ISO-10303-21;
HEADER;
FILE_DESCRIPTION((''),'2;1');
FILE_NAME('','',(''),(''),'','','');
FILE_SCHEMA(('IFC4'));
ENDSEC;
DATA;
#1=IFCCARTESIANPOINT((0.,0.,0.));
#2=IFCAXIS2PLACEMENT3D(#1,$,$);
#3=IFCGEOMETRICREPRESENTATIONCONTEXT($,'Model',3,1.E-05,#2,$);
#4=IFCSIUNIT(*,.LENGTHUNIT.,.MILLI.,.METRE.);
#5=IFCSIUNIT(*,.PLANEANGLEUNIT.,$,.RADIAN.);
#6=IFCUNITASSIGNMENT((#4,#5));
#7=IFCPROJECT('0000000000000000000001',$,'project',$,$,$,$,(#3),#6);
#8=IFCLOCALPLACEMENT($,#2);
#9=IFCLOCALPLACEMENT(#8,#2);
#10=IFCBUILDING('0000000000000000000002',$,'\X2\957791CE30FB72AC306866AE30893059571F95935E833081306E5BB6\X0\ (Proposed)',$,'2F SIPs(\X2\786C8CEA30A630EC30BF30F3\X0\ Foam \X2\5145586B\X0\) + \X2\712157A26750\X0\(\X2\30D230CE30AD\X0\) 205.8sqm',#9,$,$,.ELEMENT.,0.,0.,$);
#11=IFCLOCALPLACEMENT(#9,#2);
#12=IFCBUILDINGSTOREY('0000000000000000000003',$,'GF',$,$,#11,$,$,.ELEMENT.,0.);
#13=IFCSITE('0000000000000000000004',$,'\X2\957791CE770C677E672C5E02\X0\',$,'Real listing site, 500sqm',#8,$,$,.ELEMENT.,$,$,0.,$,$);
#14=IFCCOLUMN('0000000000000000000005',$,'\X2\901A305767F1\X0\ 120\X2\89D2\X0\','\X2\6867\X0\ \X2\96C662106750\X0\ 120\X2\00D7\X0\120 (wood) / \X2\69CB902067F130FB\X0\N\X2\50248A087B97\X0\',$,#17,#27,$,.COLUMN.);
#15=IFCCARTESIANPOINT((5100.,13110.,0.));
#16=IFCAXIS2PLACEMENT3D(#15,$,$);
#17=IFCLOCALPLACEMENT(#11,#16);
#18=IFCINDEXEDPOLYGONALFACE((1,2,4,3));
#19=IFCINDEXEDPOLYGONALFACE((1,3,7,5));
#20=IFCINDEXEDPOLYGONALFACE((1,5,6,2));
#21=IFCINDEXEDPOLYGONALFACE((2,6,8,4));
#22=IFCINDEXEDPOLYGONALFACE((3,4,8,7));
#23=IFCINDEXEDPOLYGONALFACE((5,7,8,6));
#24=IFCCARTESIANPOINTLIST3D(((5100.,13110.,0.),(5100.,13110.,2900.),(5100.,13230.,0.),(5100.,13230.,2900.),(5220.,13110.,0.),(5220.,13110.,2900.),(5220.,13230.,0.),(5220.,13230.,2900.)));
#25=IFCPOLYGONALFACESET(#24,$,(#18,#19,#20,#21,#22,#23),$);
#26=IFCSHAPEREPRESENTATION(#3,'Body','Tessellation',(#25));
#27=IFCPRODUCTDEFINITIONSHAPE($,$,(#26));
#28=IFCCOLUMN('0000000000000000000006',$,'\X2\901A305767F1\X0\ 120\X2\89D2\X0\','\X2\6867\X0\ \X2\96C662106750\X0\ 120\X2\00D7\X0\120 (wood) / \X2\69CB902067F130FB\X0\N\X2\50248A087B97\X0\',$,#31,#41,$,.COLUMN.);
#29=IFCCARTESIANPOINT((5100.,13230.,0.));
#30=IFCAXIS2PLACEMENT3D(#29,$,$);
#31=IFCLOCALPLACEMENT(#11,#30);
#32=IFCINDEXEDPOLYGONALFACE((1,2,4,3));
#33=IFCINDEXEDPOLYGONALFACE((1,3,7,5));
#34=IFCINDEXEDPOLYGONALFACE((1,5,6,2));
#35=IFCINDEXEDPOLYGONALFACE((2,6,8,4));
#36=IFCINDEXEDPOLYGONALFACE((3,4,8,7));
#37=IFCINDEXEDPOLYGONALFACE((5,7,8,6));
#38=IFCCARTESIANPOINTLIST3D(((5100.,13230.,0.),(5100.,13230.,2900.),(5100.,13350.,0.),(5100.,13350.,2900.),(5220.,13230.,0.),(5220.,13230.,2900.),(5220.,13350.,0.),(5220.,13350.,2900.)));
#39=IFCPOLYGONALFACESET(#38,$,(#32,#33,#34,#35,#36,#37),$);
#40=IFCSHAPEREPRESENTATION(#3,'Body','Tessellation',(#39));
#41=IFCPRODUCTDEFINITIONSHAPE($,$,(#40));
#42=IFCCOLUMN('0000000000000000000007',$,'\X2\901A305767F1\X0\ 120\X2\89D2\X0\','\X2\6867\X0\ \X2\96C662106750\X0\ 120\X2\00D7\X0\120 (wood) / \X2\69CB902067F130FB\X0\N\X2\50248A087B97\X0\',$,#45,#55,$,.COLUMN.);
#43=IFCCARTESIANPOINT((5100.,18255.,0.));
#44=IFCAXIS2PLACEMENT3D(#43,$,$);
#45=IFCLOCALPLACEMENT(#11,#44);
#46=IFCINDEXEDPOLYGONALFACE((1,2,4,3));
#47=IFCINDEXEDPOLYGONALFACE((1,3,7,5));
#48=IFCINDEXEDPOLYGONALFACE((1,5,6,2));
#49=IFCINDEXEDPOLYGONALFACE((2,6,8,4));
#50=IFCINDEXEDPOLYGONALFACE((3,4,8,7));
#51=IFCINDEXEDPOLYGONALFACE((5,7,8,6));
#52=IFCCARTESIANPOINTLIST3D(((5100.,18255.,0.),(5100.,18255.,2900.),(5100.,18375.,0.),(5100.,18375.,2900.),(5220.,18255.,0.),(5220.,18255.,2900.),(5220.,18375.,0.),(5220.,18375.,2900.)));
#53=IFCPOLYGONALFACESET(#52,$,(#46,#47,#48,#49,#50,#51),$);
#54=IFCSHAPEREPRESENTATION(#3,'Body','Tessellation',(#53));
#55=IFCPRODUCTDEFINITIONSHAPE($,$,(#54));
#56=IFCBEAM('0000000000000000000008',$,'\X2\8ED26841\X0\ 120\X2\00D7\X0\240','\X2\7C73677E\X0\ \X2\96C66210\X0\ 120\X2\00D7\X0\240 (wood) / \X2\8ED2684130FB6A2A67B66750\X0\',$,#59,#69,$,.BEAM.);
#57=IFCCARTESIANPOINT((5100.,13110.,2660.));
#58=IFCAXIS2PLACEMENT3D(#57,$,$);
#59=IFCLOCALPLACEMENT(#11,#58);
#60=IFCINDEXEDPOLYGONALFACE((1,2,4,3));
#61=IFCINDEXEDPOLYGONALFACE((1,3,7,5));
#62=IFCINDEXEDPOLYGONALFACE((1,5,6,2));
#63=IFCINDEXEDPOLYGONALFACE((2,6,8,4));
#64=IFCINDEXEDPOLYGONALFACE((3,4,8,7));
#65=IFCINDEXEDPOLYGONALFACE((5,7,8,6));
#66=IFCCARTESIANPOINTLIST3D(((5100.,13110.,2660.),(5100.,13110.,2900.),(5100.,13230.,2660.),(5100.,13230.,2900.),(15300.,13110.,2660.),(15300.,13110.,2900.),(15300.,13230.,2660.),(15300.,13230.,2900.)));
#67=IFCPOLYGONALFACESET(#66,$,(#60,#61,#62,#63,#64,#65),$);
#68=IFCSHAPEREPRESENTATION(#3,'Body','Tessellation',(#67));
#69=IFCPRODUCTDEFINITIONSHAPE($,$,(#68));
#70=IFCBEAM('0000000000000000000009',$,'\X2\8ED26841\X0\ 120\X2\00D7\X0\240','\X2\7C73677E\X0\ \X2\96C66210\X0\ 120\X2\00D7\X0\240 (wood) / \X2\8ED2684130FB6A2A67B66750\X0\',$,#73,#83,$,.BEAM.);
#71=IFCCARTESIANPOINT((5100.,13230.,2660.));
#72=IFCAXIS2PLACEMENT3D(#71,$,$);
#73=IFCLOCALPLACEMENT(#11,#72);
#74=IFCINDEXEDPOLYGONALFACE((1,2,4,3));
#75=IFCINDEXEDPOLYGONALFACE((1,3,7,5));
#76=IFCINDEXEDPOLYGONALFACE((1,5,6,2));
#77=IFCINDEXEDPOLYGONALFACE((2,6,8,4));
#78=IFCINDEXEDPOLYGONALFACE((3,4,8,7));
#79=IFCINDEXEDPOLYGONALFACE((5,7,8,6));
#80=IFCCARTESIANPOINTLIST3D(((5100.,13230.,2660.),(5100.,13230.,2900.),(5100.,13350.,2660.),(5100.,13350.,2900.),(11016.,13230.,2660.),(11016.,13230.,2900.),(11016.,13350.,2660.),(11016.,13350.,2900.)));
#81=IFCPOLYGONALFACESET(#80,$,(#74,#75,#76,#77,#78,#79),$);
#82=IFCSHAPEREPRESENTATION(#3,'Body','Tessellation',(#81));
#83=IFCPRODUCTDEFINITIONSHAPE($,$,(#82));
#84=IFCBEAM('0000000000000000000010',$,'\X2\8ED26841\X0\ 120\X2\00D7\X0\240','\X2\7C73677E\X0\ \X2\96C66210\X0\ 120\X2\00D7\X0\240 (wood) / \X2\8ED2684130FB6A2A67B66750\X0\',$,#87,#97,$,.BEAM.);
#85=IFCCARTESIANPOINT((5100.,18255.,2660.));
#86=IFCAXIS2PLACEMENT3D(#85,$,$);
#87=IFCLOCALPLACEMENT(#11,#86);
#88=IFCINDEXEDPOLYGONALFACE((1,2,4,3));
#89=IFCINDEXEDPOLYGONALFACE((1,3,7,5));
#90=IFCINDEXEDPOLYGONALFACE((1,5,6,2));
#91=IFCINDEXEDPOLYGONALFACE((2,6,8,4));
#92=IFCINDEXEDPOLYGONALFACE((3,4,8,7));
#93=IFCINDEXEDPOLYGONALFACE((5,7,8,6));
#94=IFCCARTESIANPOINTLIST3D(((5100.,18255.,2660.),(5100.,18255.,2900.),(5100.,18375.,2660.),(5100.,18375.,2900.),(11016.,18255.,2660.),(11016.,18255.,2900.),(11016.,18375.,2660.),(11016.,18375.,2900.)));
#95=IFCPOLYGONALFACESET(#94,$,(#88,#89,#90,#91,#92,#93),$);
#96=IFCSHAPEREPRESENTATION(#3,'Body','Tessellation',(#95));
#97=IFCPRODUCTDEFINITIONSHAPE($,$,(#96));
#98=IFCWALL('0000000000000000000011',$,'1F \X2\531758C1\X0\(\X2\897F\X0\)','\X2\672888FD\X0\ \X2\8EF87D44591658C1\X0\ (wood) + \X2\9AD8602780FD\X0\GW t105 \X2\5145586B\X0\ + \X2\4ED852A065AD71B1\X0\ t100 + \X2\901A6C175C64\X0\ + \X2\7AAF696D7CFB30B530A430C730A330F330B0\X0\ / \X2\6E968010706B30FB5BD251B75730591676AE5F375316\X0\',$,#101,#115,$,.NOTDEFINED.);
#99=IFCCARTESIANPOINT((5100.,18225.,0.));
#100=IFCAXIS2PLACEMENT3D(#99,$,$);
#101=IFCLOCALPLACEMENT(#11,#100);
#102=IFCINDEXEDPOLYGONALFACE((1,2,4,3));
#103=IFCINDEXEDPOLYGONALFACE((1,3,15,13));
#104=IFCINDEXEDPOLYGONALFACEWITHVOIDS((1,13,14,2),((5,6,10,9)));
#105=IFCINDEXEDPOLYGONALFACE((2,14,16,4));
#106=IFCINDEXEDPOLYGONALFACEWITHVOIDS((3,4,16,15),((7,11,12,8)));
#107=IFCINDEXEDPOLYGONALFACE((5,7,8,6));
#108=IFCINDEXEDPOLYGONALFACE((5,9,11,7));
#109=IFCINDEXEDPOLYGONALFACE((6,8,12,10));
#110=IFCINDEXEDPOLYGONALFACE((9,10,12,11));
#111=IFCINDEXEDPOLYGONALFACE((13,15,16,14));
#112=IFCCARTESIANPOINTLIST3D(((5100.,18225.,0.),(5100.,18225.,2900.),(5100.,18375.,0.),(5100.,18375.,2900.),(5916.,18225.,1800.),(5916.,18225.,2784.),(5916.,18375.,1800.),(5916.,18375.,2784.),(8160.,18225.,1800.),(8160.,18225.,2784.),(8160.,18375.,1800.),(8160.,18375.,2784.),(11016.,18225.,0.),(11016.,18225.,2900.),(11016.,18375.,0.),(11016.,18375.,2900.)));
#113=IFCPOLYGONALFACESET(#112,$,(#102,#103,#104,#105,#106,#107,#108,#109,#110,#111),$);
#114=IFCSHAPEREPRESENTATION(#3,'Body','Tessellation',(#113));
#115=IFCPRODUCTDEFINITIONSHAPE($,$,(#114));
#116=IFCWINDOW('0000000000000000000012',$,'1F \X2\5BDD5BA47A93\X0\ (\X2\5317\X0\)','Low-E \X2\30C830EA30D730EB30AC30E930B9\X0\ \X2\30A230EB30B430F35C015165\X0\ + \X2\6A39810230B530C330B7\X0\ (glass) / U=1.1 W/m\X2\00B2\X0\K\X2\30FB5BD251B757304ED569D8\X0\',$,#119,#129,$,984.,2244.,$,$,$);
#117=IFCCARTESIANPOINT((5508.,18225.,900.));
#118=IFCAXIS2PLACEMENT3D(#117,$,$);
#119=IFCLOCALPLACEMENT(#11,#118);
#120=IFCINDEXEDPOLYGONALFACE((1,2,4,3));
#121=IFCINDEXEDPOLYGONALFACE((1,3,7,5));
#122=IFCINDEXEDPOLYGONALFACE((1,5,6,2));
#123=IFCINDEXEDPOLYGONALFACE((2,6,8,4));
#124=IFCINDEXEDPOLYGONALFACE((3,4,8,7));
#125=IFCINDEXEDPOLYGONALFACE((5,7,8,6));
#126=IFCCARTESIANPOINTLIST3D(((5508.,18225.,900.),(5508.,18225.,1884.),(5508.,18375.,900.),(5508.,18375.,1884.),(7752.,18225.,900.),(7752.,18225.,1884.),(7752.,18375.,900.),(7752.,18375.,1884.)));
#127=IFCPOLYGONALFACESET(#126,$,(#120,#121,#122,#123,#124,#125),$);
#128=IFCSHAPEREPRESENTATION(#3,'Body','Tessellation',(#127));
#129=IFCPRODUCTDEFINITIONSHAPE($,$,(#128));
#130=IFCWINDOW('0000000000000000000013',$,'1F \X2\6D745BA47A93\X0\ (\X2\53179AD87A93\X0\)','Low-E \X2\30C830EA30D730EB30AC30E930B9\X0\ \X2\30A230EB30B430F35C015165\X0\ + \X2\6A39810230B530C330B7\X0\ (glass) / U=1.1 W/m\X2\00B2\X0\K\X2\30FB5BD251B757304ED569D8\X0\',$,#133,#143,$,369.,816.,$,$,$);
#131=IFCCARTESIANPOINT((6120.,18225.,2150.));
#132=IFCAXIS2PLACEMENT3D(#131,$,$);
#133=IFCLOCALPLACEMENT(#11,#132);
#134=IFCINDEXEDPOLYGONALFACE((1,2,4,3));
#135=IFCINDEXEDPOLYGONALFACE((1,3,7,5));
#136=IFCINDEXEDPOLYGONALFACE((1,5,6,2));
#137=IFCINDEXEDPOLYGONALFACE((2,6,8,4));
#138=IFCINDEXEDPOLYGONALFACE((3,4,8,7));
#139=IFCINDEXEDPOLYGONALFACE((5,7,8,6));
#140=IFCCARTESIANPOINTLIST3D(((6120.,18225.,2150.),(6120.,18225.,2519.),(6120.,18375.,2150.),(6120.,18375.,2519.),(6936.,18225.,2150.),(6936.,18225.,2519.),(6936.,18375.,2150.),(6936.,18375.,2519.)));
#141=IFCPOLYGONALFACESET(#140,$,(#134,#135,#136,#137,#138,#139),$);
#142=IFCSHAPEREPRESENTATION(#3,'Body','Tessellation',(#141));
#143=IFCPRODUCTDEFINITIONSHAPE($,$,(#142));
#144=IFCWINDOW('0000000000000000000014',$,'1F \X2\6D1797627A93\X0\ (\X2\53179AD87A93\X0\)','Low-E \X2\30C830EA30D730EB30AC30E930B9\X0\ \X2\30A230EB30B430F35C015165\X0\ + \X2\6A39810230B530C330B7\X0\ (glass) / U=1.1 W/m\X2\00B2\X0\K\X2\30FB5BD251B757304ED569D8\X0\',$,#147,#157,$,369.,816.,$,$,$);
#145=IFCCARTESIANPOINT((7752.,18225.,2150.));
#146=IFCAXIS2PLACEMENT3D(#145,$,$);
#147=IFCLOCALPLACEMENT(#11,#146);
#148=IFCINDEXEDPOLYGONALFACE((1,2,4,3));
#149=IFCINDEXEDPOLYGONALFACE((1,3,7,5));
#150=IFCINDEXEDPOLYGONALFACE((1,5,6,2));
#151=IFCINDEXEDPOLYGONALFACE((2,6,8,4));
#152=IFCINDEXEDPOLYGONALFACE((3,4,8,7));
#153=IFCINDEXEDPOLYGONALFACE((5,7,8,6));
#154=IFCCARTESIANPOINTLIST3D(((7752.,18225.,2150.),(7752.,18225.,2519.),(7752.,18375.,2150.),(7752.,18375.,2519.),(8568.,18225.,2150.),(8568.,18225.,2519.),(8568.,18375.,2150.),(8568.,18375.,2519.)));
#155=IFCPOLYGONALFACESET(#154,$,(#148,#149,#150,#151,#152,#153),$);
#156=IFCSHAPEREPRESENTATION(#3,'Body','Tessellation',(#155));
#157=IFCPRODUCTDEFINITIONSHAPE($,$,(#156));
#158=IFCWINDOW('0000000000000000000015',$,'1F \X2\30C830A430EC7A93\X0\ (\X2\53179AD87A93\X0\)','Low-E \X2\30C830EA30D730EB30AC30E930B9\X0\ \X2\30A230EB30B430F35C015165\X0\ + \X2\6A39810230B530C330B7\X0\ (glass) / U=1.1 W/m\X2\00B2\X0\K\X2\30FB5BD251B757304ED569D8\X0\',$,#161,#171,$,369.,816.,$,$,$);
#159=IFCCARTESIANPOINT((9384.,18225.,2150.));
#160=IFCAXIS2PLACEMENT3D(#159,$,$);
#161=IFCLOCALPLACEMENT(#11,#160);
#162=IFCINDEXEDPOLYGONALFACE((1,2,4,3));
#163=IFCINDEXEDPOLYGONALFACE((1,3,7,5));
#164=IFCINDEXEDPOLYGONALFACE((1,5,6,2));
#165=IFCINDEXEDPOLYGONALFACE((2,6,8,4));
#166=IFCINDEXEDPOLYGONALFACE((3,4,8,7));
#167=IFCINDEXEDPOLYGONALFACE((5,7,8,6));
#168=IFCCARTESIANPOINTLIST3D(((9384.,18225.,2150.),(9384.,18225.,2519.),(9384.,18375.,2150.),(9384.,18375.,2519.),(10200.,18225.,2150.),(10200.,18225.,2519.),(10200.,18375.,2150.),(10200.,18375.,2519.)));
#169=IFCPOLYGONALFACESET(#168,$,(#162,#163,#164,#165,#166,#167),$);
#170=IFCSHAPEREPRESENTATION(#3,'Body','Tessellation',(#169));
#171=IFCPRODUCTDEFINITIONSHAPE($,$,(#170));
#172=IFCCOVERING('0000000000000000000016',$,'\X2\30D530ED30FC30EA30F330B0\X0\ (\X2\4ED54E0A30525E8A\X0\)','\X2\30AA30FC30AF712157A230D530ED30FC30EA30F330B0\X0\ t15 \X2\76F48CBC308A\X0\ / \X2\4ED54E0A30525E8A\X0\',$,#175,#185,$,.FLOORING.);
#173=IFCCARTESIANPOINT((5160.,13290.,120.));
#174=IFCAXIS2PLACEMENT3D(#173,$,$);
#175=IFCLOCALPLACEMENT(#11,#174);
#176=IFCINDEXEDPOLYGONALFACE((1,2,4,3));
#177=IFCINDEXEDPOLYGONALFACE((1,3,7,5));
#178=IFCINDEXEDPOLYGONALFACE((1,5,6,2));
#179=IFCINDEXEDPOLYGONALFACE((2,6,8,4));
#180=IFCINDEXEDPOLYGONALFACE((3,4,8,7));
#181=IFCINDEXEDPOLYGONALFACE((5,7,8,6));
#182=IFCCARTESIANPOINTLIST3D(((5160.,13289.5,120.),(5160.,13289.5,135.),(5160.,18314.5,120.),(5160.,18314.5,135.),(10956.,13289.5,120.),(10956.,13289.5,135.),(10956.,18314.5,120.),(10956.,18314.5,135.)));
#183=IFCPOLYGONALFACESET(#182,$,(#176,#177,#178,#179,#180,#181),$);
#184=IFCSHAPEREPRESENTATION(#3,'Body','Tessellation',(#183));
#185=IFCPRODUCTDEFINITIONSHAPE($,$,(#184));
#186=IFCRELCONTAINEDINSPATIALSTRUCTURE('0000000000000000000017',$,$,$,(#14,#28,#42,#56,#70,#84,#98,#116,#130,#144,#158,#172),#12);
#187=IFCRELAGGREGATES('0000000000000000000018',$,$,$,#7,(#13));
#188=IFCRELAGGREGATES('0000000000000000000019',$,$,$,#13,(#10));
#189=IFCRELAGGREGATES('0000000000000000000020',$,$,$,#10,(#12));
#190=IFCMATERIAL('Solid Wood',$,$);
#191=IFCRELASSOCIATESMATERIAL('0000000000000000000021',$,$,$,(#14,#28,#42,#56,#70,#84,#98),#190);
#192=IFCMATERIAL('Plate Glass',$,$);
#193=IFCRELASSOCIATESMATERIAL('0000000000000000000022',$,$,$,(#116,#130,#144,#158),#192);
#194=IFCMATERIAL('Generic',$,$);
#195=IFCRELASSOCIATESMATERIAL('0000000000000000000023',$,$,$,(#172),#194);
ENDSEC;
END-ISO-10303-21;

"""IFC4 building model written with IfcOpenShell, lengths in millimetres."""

from ifc_helpers import new_model, si_unit, frame, frame_2d, origin, place, context, project, spatial, rectangle, extrude, material, element, fill, save


model = new_model("IFC4")

# Units and contexts
model_context = context("Model", 3, precision=1e-05, world=origin())
ifc_project = project(units=[si_unit("LENGTHUNIT", "METRE", prefix="MILLI"), si_unit("PLANEANGLEUNIT", "RADIAN")], contexts=[model_context])

# Site, building, storey
site_placement = place(None, origin())
site = spatial("IfcSite", under=ifc_project, at=site_placement, Name="長野県松本市", ObjectType="Real listing site, 500sqm", CompositionType="ELEMENT", RefElevation=0.0)
building_placement = place(site_placement, origin())
building = spatial("IfcBuilding", under=site, at=building_placement, Name="長野・犬と暮らす土間広めの家 (Proposed)", ObjectType="2F SIPs(硬質ウレタン Foam 充填) + 無垢材(ヒノキ) 205.8sqm", CompositionType="ELEMENT", ElevationOfRefHeight=0.0, ElevationOfTerrain=0.0)
storey_placement = place(building_placement, origin())
storey = spatial("IfcBuildingStorey", under=building, at=storey_placement, Name="GF", CompositionType="ELEMENT", Elevation=0.0)

# Columns
ifc_material_1 = material(Name="Solid Wood")
column_1_placement = place(storey_placement, frame((5100.0, 13110.0, 0.0)))
element("IfcColumn", 1, at=column_1_placement, inside=storey, material=ifc_material_1, Name="通し柱 120角", Description="桧 集成材 120×120 (wood) / 構造柱・N値計算", PredefinedType="COLUMN", context=model_context, shape_type="SweptSolid", body=[
    extrude(rectangle(XDim=120.0, YDim=120.0, at=frame_2d((60.0, 60.0))), frame((5100.0, 13110.0, 0.0)), (0.0, 0.0, 1.0), 2900.0),
])
column_2_placement = place(storey_placement, frame((5100.0, 13230.0, 0.0)))
element("IfcColumn", 2, at=column_2_placement, inside=storey, material=ifc_material_1, Name="通し柱 120角", Description="桧 集成材 120×120 (wood) / 構造柱・N値計算", PredefinedType="COLUMN", context=model_context, shape_type="SweptSolid", body=[
    extrude(rectangle(XDim=120.0, YDim=120.0, at=frame_2d((60.0, 60.0))), frame((5100.0, 13230.0, 0.0)), (0.0, 0.0, 1.0), 2900.0),
])
column_3_placement = place(storey_placement, frame((5100.0, 18255.0, 0.0)))
element("IfcColumn", 3, at=column_3_placement, inside=storey, material=ifc_material_1, Name="通し柱 120角", Description="桧 集成材 120×120 (wood) / 構造柱・N値計算", PredefinedType="COLUMN", context=model_context, shape_type="SweptSolid", body=[
    extrude(rectangle(XDim=120.0, YDim=120.0, at=frame_2d((60.0, 60.0))), frame((5100.0, 18255.0, 0.0)), (0.0, 0.0, 1.0), 2900.0),
])

# Beams
beam_1_placement = place(storey_placement, frame((5100.0, 13110.0, 2660.0)))
element("IfcBeam", 4, at=beam_1_placement, inside=storey, material=ifc_material_1, Name="軒桁 120×240", Description="米松 集成 120×240 (wood) / 軒桁・横架材", PredefinedType="BEAM", context=model_context, shape_type="SweptSolid", body=[
    extrude(rectangle(XDim=10200.0, YDim=120.0, at=frame_2d((5100.0, 60.0))), frame((5100.0, 13110.0, 2660.0)), (0.0, 0.0, 1.0), 240.0),
])
beam_2_placement = place(storey_placement, frame((5100.0, 13230.0, 2660.0)))
element("IfcBeam", 5, at=beam_2_placement, inside=storey, material=ifc_material_1, Name="軒桁 120×240", Description="米松 集成 120×240 (wood) / 軒桁・横架材", PredefinedType="BEAM", context=model_context, shape_type="SweptSolid", body=[
    extrude(rectangle(XDim=5916.0, YDim=120.0, at=frame_2d((2958.0, 60.0))), frame((5100.0, 13230.0, 2660.0)), (0.0, 0.0, 1.0), 240.0),
])
beam_3_placement = place(storey_placement, frame((5100.0, 18255.0, 2660.0)))
element("IfcBeam", 6, at=beam_3_placement, inside=storey, material=ifc_material_1, Name="軒桁 120×240", Description="米松 集成 120×240 (wood) / 軒桁・横架材", PredefinedType="BEAM", context=model_context, shape_type="SweptSolid", body=[
    extrude(rectangle(XDim=5916.0, YDim=120.0, at=frame_2d((2958.0, 60.0))), frame((5100.0, 18255.0, 2660.0)), (0.0, 0.0, 1.0), 240.0),
])

# Wall, openings, windows
wall_1_placement = place(storey_placement, frame((5100.0, 18225.0, 0.0)))
wall_1 = element("IfcWall", 7, at=wall_1_placement, inside=storey, material=ifc_material_1, Name="1F 北壁(西)", Description="木製 軸組外壁 (wood) + 高性能GW t105 充填 + 付加断熱 t100 + 通気層 + 窯業系サイディング / 準耐火・寒冷地外皮強化", PredefinedType="NOTDEFINED", context=model_context, shape_type="SweptSolid", body=[
    extrude(rectangle(XDim=5916.0, YDim=150.0, at=frame_2d((2958.0, 75.0))), frame((5100.0, 18225.0, 0.0)), (0.0, 0.0, 1.0), 2900.0),
])
opening_1_placement = place(storey_placement, frame((5508.0, 18225.0, 900.0)))
opening_1 = element("IfcOpeningElement", 8, at=opening_1_placement, cuts=wall_1, PredefinedType="NOTDEFINED", context=model_context, shape_type="SweptSolid", body=[
    extrude(rectangle(XDim=2244.0, YDim=150.0, at=frame_2d((1122.0, 75.0))), frame((5508.0, 18225.0, 900.0)), (0.0, 0.0, 1.0), 984.0),
])
opening_2_placement = place(storey_placement, frame((6120.0, 18225.0, 2150.0)))
opening_2 = element("IfcOpeningElement", 9, at=opening_2_placement, cuts=wall_1, PredefinedType="NOTDEFINED", context=model_context, shape_type="SweptSolid", body=[
    extrude(rectangle(XDim=816.0, YDim=150.0, at=frame_2d((408.0, 75.0))), frame((6120.0, 18225.0, 2150.0)), (0.0, 0.0, 1.0), 369.0),
])
opening_3_placement = place(storey_placement, frame((7752.0, 18225.0, 2150.0)))
opening_3 = element("IfcOpeningElement", 10, at=opening_3_placement, cuts=wall_1, PredefinedType="NOTDEFINED", context=model_context, shape_type="SweptSolid", body=[
    extrude(rectangle(XDim=816.0, YDim=150.0, at=frame_2d((408.0, 75.0))), frame((7752.0, 18225.0, 2150.0)), (0.0, 0.0, 1.0), 369.0),
])
opening_4_placement = place(storey_placement, frame((9384.0, 18225.0, 2150.0)))
opening_4 = element("IfcOpeningElement", 11, at=opening_4_placement, cuts=wall_1, PredefinedType="NOTDEFINED", context=model_context, shape_type="SweptSolid", body=[
    extrude(rectangle(XDim=816.0, YDim=150.0, at=frame_2d((408.0, 75.0))), frame((9384.0, 18225.0, 2150.0)), (0.0, 0.0, 1.0), 369.0),
])
ifc_material_2 = material(Name="Plate Glass")
window_1_placement = place(storey_placement, frame((5508.0, 18225.0, 900.0)))
window_1 = element("IfcWindow", 12, at=window_1_placement, inside=storey, material=ifc_material_2, Name="1F 寝室窓 (北)", Description="Low-E トリプルガラス アルゴン封入 + 樹脂サッシ (glass) / U=1.1 W/m²K・寒冷地仕様", OverallHeight=984.0, OverallWidth=2244.0, context=model_context, shape_type="SweptSolid", body=[
    extrude(rectangle(XDim=2244.0, YDim=150.0, at=frame_2d((1122.0, 75.0))), frame((5508.0, 18225.0, 900.0)), (0.0, 0.0, 1.0), 984.0),
])
fill(opening_1, window_1)
window_2_placement = place(storey_placement, frame((6120.0, 18225.0, 2150.0)))
window_2 = element("IfcWindow", 13, at=window_2_placement, inside=storey, material=ifc_material_2, Name="1F 浴室窓 (北高窓)", Description="Low-E トリプルガラス アルゴン封入 + 樹脂サッシ (glass) / U=1.1 W/m²K・寒冷地仕様", OverallHeight=369.0, OverallWidth=816.0, context=model_context, shape_type="SweptSolid", body=[
    extrude(rectangle(XDim=816.0, YDim=150.0, at=frame_2d((408.0, 75.0))), frame((6120.0, 18225.0, 2150.0)), (0.0, 0.0, 1.0), 369.0),
])
fill(opening_2, window_2)
window_3_placement = place(storey_placement, frame((7752.0, 18225.0, 2150.0)))
window_3 = element("IfcWindow", 14, at=window_3_placement, inside=storey, material=ifc_material_2, Name="1F 洗面窓 (北高窓)", Description="Low-E トリプルガラス アルゴン封入 + 樹脂サッシ (glass) / U=1.1 W/m²K・寒冷地仕様", OverallHeight=369.0, OverallWidth=816.0, context=model_context, shape_type="SweptSolid", body=[
    extrude(rectangle(XDim=816.0, YDim=150.0, at=frame_2d((408.0, 75.0))), frame((7752.0, 18225.0, 2150.0)), (0.0, 0.0, 1.0), 369.0),
])
fill(opening_3, window_3)
window_4_placement = place(storey_placement, frame((9384.0, 18225.0, 2150.0)))
window_4 = element("IfcWindow", 15, at=window_4_placement, inside=storey, material=ifc_material_2, Name="1F トイレ窓 (北高窓)", Description="Low-E トリプルガラス アルゴン封入 + 樹脂サッシ (glass) / U=1.1 W/m²K・寒冷地仕様", OverallHeight=369.0, OverallWidth=816.0, context=model_context, shape_type="SweptSolid", body=[
    extrude(rectangle(XDim=816.0, YDim=150.0, at=frame_2d((408.0, 75.0))), frame((9384.0, 18225.0, 2150.0)), (0.0, 0.0, 1.0), 369.0),
])
fill(opening_4, window_4)

# Covering
ifc_material_3 = material(Name="Generic")
covering_placement = place(storey_placement, frame((5160.0, 13290.0, 120.0)))
element("IfcCovering", 16, at=covering_placement, inside=storey, material=ifc_material_3, Name="フローリング (仕上げ床)", Description="オーク無垢フローリング t15 直貼り / 仕上げ床", PredefinedType="FLOORING", context=model_context, shape_type="SweptSolid", body=[
    extrude(rectangle(XDim=5796.0, YDim=5025.0, at=frame_2d((2898.0, 2512.0))), frame((5160.0, 13290.0, 120.0)), (0.0, 0.0, 1.0), 15.0),
])

save(model, "model.ifc")
